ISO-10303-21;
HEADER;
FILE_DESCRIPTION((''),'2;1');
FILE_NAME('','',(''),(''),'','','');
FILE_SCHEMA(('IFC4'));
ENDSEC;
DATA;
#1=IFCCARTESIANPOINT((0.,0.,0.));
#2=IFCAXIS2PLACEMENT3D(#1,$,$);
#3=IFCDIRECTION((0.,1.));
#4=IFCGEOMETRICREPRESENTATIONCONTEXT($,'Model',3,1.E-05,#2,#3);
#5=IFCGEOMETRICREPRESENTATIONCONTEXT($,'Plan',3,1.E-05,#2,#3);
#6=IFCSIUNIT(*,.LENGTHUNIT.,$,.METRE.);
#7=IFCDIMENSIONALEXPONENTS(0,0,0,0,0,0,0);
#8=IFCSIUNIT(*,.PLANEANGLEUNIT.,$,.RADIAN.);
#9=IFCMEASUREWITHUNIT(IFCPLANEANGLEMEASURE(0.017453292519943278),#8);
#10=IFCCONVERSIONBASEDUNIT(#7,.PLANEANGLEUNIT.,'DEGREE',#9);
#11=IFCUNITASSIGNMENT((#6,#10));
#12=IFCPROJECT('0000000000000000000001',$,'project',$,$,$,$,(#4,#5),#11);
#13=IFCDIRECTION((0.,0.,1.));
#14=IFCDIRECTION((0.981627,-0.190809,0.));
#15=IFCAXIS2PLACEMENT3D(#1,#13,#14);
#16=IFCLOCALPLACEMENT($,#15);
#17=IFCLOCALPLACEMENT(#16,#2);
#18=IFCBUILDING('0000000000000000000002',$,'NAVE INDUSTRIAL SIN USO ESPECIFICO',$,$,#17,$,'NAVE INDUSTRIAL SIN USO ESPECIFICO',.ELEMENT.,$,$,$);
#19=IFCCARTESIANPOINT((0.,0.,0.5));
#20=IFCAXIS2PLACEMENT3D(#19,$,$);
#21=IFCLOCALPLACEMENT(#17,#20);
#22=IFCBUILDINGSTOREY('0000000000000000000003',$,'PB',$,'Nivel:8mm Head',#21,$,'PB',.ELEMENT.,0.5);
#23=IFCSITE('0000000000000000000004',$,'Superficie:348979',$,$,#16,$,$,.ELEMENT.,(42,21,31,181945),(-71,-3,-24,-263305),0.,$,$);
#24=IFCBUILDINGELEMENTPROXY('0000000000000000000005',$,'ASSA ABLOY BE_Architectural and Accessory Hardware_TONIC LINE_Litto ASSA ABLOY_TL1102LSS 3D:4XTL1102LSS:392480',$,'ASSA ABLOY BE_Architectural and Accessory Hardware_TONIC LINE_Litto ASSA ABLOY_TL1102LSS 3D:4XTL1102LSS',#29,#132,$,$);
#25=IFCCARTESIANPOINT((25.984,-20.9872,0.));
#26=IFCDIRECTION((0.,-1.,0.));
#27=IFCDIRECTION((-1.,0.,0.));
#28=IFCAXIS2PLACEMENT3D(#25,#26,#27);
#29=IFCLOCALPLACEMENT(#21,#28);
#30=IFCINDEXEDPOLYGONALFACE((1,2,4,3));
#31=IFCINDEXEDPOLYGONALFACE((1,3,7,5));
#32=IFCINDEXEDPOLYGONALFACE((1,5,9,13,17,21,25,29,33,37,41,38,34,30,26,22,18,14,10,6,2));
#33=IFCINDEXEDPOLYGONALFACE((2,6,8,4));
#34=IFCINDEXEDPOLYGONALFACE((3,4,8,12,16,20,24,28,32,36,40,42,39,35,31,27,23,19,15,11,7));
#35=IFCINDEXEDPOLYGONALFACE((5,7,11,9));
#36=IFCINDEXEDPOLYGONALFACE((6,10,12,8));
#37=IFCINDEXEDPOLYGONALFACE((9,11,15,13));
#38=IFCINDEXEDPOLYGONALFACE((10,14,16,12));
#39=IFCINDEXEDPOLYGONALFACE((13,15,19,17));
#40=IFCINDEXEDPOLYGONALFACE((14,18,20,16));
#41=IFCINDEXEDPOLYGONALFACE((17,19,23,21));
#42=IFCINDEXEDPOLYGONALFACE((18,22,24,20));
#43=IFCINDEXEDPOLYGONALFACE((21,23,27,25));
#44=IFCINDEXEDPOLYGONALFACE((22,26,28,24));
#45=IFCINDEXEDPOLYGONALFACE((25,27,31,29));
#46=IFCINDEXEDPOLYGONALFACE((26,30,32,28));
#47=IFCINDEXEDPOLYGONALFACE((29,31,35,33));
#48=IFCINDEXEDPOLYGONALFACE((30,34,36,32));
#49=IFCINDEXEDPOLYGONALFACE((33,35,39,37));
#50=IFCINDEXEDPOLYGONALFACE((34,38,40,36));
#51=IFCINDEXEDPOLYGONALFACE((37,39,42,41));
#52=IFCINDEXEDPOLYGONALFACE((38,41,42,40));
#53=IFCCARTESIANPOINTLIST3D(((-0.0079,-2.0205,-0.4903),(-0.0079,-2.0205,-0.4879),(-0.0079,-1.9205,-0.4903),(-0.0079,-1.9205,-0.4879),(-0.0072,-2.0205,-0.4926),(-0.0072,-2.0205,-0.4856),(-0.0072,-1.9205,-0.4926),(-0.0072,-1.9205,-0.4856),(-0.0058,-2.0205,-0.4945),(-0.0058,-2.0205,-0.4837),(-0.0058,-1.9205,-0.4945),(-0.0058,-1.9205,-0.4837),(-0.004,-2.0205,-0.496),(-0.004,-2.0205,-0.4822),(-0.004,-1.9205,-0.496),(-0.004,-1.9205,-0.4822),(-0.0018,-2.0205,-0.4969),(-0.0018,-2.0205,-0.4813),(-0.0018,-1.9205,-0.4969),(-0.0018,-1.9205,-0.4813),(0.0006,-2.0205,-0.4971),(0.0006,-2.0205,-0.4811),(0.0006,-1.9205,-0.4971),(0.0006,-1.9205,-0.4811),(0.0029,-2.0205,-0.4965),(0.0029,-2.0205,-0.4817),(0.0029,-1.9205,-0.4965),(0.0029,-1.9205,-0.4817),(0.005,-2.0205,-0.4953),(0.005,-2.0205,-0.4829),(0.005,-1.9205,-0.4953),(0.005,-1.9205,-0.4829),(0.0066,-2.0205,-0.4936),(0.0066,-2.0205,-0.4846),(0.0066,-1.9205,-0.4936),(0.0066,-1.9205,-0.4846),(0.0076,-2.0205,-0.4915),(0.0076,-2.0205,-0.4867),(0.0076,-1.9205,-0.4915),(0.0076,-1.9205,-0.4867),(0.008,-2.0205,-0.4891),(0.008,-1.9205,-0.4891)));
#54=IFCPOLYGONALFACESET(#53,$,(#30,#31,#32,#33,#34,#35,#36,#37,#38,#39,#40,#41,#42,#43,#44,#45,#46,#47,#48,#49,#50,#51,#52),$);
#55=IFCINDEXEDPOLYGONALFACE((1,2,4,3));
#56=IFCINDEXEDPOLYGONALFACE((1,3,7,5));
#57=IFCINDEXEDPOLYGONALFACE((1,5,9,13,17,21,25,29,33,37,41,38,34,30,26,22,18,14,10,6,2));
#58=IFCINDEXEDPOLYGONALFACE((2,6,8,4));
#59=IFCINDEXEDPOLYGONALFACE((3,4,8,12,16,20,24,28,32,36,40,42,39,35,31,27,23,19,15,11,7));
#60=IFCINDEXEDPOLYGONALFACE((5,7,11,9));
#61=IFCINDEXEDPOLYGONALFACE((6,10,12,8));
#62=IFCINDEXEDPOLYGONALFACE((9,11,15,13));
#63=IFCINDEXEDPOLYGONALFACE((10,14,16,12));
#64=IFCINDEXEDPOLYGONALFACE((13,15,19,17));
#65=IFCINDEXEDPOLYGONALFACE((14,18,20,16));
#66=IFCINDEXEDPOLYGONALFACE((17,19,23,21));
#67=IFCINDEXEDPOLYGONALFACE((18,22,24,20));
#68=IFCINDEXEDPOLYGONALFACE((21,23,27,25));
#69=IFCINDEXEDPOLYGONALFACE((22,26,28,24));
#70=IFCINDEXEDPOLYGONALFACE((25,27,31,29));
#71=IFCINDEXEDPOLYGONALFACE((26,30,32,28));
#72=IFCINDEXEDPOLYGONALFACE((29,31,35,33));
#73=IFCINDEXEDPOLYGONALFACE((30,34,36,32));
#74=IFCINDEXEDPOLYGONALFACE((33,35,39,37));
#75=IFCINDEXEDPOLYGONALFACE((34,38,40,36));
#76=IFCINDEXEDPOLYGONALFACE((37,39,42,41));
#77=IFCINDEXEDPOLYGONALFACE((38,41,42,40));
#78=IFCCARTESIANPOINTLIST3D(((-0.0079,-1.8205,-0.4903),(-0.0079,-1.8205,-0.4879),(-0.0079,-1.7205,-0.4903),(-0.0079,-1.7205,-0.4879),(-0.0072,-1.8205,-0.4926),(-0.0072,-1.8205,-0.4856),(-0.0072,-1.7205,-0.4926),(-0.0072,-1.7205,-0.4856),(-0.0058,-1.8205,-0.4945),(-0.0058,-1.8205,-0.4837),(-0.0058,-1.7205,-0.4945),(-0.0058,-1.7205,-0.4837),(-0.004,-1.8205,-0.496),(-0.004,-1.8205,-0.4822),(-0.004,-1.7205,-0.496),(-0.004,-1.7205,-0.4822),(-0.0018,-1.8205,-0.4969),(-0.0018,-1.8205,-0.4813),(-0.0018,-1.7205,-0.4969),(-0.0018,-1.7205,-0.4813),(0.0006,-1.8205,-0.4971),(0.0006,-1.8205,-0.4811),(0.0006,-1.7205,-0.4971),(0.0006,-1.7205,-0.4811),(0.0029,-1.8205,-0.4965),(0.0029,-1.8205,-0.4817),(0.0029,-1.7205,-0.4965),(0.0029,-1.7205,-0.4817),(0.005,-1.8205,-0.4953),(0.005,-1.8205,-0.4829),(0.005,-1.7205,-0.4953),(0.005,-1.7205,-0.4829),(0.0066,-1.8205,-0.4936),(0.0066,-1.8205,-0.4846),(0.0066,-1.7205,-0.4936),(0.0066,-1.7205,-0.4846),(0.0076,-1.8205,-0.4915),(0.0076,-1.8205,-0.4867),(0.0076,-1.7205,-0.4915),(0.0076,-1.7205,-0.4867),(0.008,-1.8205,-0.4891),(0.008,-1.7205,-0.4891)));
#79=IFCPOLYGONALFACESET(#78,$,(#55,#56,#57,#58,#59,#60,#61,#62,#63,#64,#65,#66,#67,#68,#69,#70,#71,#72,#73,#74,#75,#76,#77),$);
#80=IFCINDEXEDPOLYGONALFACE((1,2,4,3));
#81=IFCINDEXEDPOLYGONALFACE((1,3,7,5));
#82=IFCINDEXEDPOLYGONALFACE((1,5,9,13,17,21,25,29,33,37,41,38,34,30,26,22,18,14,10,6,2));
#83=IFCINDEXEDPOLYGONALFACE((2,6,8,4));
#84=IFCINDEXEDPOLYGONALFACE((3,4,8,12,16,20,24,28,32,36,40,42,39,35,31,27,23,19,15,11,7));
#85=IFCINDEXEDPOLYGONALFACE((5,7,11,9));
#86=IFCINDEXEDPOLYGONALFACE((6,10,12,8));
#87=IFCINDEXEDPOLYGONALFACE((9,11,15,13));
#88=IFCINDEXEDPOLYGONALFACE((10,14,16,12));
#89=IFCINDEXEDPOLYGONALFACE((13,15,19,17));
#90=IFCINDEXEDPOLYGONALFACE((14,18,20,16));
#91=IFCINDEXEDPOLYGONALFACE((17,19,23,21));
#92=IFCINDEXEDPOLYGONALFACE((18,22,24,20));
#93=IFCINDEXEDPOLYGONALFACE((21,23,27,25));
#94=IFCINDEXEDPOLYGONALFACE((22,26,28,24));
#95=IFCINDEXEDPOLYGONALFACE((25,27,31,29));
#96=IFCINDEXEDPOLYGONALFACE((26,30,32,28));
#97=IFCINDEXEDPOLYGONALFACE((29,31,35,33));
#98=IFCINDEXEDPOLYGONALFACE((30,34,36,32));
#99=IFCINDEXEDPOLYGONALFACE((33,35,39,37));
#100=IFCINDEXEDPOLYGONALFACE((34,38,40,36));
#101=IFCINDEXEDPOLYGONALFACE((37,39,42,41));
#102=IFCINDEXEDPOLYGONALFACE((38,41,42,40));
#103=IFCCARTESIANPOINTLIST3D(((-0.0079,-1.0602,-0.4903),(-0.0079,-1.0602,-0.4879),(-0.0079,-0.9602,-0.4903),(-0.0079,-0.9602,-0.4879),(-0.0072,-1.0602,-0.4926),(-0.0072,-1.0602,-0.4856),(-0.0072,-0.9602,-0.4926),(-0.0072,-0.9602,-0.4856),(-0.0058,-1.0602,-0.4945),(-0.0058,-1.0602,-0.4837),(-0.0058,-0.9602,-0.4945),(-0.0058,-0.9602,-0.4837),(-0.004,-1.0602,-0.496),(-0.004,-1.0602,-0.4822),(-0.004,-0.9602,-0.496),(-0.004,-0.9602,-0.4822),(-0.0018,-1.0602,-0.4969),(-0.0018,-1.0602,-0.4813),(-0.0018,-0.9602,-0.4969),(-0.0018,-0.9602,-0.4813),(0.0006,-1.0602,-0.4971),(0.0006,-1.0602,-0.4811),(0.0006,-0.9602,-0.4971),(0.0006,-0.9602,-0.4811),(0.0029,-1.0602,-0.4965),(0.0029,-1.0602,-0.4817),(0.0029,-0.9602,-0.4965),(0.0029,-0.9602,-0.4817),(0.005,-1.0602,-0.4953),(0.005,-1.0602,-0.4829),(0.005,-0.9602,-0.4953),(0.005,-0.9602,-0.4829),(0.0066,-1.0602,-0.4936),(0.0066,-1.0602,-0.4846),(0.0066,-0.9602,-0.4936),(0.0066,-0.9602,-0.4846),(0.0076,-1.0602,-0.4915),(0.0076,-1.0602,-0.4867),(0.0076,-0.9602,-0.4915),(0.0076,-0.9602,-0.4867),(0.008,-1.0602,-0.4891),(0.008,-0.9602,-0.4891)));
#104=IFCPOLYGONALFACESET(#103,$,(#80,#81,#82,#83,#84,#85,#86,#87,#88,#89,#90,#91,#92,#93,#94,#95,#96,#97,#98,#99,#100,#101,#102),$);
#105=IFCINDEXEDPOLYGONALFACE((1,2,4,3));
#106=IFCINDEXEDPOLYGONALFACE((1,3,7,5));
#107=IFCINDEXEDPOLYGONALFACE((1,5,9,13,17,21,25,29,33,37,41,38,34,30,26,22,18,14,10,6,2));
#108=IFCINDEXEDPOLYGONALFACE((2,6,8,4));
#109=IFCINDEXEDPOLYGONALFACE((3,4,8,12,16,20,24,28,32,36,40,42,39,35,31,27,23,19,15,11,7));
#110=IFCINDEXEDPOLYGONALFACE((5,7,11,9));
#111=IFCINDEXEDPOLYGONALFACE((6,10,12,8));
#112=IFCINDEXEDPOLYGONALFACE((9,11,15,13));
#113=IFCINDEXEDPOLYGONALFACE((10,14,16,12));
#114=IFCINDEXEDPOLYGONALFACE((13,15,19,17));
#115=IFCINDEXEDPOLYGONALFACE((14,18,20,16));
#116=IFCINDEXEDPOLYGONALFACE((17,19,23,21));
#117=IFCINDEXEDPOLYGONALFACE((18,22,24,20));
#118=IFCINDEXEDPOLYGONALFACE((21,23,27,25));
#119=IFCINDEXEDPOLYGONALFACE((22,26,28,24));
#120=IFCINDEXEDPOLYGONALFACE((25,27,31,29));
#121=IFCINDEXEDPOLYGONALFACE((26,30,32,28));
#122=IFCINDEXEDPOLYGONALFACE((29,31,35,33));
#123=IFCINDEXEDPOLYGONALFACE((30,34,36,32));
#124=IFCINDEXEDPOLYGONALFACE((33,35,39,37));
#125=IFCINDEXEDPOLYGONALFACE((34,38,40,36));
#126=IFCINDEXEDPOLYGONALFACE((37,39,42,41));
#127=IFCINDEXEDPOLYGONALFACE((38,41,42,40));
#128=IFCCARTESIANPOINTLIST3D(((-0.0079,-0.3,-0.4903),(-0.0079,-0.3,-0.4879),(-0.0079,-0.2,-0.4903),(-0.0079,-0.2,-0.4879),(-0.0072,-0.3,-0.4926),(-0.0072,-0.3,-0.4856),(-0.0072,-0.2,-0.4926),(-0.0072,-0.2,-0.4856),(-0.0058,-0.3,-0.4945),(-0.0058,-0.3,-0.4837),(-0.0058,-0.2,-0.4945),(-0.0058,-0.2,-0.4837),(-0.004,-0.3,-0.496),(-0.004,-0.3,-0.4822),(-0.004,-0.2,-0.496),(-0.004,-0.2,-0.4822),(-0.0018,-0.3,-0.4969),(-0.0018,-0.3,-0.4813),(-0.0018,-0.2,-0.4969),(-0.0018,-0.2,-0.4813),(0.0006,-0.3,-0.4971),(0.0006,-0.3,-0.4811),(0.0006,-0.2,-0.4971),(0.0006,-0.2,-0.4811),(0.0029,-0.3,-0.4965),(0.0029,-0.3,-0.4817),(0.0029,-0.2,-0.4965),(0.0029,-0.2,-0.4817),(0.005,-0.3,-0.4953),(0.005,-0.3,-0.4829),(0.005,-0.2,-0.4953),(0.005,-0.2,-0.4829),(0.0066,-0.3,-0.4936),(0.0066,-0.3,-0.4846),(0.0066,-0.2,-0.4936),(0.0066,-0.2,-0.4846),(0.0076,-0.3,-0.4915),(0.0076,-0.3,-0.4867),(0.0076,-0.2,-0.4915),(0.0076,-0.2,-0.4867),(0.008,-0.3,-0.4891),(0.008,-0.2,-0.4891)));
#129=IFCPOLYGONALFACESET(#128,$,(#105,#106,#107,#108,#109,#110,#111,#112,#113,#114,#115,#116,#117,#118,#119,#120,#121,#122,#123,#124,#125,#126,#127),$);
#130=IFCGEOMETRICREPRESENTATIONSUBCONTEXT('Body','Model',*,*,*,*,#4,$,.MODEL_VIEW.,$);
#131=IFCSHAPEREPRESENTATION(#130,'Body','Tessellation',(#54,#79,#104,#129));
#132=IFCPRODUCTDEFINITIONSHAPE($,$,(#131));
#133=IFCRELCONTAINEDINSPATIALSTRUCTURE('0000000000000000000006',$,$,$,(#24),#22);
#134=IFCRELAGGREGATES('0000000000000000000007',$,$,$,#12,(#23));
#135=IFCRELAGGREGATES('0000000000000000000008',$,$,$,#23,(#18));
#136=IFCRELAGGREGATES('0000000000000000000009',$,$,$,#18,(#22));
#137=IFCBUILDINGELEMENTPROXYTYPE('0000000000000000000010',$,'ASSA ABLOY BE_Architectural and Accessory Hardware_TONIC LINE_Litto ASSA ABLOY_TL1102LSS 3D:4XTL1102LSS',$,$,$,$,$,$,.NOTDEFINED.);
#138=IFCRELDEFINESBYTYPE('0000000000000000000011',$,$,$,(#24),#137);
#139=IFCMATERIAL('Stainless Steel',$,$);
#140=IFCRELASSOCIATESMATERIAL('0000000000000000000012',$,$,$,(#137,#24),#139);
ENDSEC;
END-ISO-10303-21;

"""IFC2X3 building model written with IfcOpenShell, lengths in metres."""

from ifc_helpers import new_model, entity, si_unit, converted_unit, direction, frame, frame_2d, origin, place, context, subcontext, project, spatial, circle, extrude, source, transform, mapped, material, type_object, type_shapes, element, save


model = new_model("IFC2X3")

# Units and contexts
model_context = context("Model", 3, precision=1e-05, world=origin(), true_north=direction((0.0, 1.0)))
plan_context = context("Plan", 3, precision=1e-05, world=origin(), true_north=direction((0.0, 1.0)))
body_context = subcontext(model_context, "Body", "Model", "MODEL_VIEW")
ifc_project = project(units=[si_unit("LENGTHUNIT", "METRE"), converted_unit("PLANEANGLEUNIT", "DEGREE", entity("IfcPlaneAngleMeasure", 0.017453292519943278), si_unit("PLANEANGLEUNIT", "RADIAN"), dimensions=[0, 0, 0, 0, 0, 0, 0])], contexts=[model_context, plan_context])

# Site, building, storey
site_placement = place(None, frame((0.0, 0.0, 0.0), z_axis=(0.0, 0.0, 1.0), x_axis=(0.981627, -0.190809, 0.0)))
site = spatial("IfcSite", under=ifc_project, at=site_placement, Name="Superficie:348979", CompositionType="ELEMENT", RefLatitude=(42, 21, 31, 181945), RefLongitude=(-71, -3, -24, -263305), RefElevation=0.0)
building_placement = place(site_placement, origin())
building = spatial("IfcBuilding", under=site, at=building_placement, Name="NAVE INDUSTRIAL SIN USO ESPECIFICO", LongName="NAVE INDUSTRIAL SIN USO ESPECIFICO", CompositionType="ELEMENT")
storey_placement = place(building_placement, frame((0.0, 0.0, 0.5)))
storey = spatial("IfcBuildingStorey", under=building, at=storey_placement, Name="PB", ObjectType="Nivel:8mm Head", LongName="PB", CompositionType="ELEMENT", Elevation=0.5)

# Building element proxy
ifc_material_1 = material(Name="Stainless Steel")
building_element_proxy_type_1 = type_object("IfcBuildingElementProxyType", Name="ASSA ABLOY BE_Architectural and Accessory Hardware_TONIC LINE_Litto ASSA ABLOY_TL1102LSS 3D:4XTL1102LSS", PredefinedType="NOTDEFINED", material=ifc_material_1)
shared_shape_1 = source(origin(), body_context, "Body", "SweptSolid", [
    extrude(circle(Radius=0.008, at=frame_2d((0.0, 0.0), x_axis=(1.0, 0.0))), frame((0.0, -2.0205, -0.4891), z_axis=(0.0, 1.0, 0.0), x_axis=(1.0, 0.0, 0.0)), (0.0, 0.0, 1.0), 0.1),
    extrude(circle(Radius=0.008, at=frame_2d((0.0, 0.0), x_axis=(1.0, 0.0))), frame((0.0, -1.8205, -0.4891), z_axis=(0.0, 1.0, 0.0), x_axis=(1.0, 0.0, 0.0)), (0.0, 0.0, 1.0), 0.1),
    extrude(circle(Radius=0.008, at=frame_2d((0.0, 0.0), x_axis=(1.0, 0.0))), frame((0.0, -1.0602, -0.4891), z_axis=(0.0, 1.0, 0.0), x_axis=(1.0, 0.0, 0.0)), (0.0, 0.0, 1.0), 0.1),
    extrude(circle(Radius=0.008, at=frame_2d((0.0, 0.0), x_axis=(1.0, 0.0))), frame((0.0, -0.3, -0.4891), z_axis=(0.0, 1.0, 0.0), x_axis=(1.0, 0.0, 0.0)), (0.0, 0.0, 1.0), 0.1),
])
type_shapes(building_element_proxy_type_1, [shared_shape_1])
for number, where, z_axis, x_axis, name in (
    (1, (25.984, -20.9872, 0.0), (0.0, -1.0, 0.0), (-1.0, 0.0, 0.0), "ASSA ABLOY BE_Architectural and Accessory Hardware_TONIC LINE_Litto ASSA ABLOY_TL1102LSS 3D:4XTL1102LSS:392480"),
):
    element("IfcBuildingElementProxy", number, at=place(storey_placement, frame(where, z_axis=z_axis, x_axis=x_axis)), inside=storey, type_object=building_element_proxy_type_1, material=ifc_material_1, Name=name, ObjectType="ASSA ABLOY BE_Architectural and Accessory Hardware_TONIC LINE_Litto ASSA ABLOY_TL1102LSS 3D:4XTL1102LSS", context=body_context, shape_type="MappedRepresentation", body=[
        mapped(shared_shape_1, transform((0.0, 0.0, 0.0), scale=1.0)),
    ])

save(model, "model.ifc")
